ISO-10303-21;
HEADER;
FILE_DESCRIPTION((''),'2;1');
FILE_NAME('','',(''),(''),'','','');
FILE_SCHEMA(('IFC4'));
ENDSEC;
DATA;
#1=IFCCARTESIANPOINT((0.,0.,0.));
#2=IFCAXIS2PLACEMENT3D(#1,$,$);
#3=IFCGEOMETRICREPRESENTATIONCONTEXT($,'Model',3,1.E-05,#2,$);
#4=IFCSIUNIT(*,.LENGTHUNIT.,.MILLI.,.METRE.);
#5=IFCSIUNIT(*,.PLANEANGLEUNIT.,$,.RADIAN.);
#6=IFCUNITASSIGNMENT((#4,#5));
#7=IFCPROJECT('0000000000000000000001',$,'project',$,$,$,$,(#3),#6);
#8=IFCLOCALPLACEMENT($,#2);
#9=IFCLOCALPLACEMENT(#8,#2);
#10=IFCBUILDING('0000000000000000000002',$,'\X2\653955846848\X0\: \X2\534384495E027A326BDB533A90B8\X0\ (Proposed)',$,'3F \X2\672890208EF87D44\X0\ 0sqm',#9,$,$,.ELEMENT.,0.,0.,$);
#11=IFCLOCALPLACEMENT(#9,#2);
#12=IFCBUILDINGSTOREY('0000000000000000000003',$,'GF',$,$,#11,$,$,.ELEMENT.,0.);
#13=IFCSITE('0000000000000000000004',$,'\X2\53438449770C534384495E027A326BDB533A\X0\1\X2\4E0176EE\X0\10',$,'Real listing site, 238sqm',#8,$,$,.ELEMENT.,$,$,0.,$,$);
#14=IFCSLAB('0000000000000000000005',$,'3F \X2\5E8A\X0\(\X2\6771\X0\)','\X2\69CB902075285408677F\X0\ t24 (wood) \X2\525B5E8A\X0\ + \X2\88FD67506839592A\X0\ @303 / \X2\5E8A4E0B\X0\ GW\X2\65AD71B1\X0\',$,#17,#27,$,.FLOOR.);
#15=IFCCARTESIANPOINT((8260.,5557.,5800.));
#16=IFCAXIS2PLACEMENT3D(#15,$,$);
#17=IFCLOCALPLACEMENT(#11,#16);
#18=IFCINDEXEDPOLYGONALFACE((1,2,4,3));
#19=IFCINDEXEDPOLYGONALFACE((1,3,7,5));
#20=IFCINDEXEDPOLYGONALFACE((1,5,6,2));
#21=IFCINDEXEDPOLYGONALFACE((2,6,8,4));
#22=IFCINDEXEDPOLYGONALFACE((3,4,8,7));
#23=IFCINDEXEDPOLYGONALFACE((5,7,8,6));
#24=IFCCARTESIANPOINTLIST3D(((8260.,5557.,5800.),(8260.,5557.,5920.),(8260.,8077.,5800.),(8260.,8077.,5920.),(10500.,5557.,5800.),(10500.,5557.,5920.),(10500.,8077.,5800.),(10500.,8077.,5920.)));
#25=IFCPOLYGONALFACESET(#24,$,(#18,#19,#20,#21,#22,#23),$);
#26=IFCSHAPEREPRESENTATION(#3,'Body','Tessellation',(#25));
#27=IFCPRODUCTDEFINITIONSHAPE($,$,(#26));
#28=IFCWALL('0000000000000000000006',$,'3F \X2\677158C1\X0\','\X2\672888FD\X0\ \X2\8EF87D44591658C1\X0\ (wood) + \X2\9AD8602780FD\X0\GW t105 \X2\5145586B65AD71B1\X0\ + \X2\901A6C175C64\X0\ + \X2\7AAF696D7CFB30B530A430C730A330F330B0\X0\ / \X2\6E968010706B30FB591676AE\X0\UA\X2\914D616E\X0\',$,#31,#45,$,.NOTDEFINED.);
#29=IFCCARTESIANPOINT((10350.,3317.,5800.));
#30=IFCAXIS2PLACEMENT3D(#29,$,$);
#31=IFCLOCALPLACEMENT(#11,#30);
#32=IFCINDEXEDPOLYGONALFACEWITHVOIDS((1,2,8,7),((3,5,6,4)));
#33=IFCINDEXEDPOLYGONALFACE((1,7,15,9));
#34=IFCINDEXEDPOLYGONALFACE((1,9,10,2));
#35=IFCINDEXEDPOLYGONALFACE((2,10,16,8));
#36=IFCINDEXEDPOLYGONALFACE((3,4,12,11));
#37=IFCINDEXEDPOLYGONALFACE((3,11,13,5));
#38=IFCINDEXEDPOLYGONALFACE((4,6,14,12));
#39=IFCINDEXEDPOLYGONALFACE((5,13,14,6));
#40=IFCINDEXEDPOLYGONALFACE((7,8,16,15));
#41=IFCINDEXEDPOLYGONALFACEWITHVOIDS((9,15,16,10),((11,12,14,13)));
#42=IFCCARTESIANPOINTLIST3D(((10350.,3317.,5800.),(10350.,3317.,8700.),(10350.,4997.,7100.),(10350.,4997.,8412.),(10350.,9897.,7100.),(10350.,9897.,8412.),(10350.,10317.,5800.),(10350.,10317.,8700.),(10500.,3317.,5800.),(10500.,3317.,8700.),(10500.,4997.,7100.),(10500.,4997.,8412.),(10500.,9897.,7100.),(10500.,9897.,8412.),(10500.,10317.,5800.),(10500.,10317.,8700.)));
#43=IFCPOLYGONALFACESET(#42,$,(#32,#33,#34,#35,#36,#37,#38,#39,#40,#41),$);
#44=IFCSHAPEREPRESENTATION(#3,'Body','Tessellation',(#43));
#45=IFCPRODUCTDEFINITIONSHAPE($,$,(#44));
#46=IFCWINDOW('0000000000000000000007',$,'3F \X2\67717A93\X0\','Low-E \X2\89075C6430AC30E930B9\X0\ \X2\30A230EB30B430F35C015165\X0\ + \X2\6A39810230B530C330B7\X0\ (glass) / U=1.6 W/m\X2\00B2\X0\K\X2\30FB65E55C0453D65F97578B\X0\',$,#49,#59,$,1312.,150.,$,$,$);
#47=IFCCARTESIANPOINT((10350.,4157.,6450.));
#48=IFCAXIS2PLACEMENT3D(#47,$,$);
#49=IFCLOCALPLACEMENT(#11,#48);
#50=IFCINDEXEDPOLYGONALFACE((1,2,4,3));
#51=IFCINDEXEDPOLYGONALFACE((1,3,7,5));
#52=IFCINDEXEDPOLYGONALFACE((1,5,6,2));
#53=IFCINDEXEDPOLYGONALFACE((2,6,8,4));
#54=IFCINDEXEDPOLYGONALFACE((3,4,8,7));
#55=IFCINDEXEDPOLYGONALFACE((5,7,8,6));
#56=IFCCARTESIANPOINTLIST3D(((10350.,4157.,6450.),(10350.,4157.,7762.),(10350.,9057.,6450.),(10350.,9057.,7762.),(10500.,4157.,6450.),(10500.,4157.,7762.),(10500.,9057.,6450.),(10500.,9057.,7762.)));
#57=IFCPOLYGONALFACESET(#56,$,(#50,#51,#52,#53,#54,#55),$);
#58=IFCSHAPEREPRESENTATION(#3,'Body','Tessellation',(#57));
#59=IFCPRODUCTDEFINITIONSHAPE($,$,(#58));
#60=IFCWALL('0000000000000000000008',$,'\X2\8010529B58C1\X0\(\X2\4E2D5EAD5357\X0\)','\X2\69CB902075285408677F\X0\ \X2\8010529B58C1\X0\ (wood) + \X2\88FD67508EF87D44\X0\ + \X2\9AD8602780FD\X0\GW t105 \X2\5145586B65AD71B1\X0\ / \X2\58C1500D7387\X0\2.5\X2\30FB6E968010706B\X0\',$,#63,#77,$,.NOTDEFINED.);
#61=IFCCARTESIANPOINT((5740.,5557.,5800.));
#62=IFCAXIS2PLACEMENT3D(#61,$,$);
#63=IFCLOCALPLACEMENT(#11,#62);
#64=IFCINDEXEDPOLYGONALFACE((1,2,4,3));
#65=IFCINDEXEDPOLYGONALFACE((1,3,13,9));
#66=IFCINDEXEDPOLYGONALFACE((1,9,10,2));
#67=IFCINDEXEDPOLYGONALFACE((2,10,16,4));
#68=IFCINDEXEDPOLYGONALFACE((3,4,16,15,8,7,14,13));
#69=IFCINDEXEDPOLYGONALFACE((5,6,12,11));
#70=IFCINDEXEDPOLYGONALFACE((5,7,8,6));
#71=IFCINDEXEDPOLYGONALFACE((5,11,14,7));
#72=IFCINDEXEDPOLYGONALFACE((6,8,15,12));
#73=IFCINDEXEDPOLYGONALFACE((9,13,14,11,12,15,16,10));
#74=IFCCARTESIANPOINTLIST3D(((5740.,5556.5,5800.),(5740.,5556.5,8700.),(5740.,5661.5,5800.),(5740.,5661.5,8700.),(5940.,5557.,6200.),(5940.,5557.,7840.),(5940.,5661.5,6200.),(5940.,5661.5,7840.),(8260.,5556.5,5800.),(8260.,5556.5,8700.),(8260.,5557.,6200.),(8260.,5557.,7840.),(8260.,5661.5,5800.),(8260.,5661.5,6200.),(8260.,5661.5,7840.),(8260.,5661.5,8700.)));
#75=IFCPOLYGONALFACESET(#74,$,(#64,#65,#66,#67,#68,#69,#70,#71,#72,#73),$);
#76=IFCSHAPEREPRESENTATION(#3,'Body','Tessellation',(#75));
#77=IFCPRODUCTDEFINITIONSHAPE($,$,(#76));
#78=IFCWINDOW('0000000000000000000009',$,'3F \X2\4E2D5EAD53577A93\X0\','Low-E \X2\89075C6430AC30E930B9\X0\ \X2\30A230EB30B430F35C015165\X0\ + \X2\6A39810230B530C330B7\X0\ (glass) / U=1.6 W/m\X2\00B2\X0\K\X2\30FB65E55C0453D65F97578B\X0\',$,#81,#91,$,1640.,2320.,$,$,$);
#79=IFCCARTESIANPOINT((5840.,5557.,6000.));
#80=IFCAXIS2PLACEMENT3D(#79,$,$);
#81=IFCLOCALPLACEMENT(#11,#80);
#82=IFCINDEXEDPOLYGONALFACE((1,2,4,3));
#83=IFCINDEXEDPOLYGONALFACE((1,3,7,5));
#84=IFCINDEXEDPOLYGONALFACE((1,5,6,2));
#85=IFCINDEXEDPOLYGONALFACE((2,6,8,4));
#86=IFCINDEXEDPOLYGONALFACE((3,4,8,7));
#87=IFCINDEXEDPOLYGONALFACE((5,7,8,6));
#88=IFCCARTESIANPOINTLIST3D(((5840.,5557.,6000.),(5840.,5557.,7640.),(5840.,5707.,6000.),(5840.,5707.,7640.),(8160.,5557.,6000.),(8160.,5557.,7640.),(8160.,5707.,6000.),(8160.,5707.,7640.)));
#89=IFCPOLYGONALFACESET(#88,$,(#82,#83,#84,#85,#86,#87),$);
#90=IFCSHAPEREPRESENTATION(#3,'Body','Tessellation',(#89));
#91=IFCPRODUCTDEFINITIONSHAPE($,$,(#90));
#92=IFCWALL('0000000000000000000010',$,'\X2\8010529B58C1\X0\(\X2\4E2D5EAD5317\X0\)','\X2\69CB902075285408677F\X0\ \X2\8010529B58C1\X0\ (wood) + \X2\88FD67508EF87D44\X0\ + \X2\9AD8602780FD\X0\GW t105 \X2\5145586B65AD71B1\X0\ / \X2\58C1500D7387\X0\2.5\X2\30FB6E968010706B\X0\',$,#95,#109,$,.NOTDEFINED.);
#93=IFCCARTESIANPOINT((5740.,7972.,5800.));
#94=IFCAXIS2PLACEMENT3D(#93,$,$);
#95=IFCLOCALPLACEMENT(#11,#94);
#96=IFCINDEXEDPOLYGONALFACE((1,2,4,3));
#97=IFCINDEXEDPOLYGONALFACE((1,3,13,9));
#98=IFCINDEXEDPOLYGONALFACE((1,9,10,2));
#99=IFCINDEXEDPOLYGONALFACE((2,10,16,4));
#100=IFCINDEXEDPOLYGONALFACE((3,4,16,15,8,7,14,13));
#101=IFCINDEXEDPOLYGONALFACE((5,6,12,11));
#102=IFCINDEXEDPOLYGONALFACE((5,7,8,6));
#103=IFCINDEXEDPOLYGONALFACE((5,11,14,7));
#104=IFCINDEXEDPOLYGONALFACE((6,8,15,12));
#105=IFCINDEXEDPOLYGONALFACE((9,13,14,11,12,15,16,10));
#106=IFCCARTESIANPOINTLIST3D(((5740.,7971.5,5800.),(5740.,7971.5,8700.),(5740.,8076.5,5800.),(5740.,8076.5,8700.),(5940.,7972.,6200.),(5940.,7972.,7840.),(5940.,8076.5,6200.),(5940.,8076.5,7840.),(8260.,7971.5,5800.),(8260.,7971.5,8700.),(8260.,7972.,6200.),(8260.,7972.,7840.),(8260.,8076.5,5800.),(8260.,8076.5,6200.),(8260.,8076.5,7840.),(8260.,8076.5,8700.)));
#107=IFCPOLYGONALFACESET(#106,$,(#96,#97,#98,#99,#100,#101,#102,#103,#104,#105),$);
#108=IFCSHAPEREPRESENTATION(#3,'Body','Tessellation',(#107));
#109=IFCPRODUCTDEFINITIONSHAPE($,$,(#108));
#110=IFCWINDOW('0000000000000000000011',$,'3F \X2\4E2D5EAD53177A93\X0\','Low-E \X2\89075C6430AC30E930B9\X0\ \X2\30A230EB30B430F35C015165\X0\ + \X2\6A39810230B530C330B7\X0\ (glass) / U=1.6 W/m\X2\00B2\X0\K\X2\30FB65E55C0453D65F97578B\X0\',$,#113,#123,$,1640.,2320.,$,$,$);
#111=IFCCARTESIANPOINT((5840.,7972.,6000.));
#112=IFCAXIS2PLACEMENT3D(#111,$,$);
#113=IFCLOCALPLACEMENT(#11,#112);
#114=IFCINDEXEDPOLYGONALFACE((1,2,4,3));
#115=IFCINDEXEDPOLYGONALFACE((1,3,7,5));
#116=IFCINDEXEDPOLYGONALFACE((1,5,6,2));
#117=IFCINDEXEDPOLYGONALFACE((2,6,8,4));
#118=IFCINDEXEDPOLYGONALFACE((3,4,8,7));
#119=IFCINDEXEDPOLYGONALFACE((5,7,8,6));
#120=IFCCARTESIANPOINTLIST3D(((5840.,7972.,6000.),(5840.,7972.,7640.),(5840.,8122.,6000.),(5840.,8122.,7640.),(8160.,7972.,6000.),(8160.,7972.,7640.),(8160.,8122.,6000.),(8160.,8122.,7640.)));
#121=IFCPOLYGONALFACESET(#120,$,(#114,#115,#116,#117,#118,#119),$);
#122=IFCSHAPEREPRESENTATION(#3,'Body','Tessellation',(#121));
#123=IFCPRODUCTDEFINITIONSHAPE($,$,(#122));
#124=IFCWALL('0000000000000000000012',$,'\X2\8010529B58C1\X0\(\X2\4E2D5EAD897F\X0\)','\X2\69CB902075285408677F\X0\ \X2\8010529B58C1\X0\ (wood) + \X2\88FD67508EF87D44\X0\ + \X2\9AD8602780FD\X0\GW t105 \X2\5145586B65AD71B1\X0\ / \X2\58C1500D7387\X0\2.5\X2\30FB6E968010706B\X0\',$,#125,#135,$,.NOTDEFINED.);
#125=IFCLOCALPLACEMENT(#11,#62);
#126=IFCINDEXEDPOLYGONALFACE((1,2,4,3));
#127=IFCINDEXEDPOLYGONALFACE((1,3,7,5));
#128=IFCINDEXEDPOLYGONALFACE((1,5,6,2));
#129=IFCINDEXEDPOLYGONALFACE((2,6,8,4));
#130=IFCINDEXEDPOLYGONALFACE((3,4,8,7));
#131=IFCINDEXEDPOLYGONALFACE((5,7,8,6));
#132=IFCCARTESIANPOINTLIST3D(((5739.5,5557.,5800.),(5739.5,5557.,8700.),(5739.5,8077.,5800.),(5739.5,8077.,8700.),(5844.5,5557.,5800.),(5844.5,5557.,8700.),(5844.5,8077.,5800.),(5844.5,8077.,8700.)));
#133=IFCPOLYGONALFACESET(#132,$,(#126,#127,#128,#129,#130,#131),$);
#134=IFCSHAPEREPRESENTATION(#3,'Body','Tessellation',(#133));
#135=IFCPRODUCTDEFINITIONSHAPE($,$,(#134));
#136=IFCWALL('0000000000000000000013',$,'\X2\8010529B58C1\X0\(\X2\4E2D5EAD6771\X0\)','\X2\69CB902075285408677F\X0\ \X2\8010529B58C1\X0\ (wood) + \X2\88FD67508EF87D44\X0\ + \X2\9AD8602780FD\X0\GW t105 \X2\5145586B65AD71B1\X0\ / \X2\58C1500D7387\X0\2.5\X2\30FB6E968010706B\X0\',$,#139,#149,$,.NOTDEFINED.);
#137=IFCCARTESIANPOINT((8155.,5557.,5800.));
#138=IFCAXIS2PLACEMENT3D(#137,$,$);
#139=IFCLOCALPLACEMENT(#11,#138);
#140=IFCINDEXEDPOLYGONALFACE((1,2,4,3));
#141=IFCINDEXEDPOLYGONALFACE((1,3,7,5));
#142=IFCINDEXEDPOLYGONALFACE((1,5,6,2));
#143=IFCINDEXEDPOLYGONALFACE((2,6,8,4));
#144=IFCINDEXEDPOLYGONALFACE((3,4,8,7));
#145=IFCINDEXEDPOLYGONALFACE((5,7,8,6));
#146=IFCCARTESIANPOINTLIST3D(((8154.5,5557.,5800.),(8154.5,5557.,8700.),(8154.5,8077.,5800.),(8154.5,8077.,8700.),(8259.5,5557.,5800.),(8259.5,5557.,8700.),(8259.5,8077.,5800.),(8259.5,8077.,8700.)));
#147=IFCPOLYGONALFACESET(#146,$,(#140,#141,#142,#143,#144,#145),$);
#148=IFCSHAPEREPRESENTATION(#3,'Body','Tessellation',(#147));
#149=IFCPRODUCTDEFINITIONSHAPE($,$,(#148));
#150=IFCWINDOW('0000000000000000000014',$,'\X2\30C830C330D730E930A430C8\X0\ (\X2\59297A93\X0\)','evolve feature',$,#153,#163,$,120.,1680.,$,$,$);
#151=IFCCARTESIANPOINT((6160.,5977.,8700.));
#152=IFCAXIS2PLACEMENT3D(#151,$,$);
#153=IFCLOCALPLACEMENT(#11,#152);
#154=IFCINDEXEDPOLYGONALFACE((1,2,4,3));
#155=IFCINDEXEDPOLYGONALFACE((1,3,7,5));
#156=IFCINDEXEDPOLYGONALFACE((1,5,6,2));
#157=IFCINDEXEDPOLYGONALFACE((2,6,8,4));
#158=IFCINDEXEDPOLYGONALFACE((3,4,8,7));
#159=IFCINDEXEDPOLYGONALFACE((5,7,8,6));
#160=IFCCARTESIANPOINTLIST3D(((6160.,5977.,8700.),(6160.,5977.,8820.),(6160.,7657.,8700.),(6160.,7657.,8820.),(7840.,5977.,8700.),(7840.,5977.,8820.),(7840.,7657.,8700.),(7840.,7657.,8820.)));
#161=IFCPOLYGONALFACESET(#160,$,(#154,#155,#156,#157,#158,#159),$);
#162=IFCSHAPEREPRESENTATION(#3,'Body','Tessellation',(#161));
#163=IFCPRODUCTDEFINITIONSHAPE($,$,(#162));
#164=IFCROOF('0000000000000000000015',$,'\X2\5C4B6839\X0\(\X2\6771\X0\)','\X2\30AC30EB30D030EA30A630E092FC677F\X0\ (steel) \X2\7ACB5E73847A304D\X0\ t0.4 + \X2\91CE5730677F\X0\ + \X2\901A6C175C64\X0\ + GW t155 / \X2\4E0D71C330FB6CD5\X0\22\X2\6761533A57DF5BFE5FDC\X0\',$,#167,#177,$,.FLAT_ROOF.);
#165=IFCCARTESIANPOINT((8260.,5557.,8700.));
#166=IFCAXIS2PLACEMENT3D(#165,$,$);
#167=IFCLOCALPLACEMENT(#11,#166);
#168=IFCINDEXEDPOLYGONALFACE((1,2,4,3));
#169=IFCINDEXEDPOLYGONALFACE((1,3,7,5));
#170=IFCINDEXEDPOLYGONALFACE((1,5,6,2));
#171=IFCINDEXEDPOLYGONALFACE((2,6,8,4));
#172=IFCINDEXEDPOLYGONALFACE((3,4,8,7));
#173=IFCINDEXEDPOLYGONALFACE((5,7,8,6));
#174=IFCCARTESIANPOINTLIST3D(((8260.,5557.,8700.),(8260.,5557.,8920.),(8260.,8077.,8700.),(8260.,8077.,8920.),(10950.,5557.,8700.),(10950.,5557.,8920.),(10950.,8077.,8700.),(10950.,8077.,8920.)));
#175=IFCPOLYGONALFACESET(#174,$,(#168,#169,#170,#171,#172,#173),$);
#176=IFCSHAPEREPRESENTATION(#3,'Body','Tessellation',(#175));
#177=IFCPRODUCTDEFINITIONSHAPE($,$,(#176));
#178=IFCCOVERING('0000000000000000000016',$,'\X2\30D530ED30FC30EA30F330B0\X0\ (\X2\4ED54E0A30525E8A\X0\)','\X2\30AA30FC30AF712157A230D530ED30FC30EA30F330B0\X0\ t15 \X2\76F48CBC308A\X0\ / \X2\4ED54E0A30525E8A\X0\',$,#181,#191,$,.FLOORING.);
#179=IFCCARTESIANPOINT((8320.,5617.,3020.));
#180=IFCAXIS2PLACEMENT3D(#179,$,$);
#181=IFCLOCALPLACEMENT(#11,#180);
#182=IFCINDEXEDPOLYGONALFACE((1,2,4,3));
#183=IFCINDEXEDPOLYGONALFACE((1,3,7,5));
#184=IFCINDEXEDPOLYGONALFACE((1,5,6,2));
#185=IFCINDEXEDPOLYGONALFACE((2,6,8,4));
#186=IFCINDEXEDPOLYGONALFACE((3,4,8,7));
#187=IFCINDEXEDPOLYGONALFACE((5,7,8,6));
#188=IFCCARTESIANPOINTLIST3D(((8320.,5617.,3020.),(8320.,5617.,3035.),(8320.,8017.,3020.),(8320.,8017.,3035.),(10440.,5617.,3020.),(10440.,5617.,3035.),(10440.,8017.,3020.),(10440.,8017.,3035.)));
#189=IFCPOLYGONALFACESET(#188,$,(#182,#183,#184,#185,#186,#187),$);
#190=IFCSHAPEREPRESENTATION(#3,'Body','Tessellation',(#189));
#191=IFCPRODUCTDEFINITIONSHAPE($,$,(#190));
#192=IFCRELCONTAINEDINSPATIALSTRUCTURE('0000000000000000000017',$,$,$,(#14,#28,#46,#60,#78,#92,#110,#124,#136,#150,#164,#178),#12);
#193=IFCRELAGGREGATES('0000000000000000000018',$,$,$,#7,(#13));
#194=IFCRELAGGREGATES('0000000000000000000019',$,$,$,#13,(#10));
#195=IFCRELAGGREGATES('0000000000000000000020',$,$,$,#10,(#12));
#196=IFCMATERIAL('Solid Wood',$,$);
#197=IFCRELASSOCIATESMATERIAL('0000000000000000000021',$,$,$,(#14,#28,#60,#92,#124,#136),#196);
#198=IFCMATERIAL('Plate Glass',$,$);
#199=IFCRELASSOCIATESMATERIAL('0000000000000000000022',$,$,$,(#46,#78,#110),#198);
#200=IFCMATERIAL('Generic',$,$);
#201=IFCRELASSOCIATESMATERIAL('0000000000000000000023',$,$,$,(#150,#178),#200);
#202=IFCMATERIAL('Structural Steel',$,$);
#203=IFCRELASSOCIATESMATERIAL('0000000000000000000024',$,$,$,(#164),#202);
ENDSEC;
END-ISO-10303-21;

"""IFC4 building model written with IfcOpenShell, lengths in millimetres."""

from ifc_helpers import new_model, si_unit, frame, frame_2d, origin, place, context, project, spatial, rectangle, extrude, material, element, fill, save


model = new_model("IFC4")

# Units and contexts
model_context = context("Model", 3, precision=1e-05, world=origin())
ifc_project = project(units=[si_unit("LENGTHUNIT", "METRE", prefix="MILLI"), si_unit("PLANEANGLEUNIT", "RADIAN")], contexts=[model_context])

# Site, building, storey
site_placement = place(None, origin())
site = spatial("IfcSite", under=ifc_project, at=site_placement, Name="千葉県千葉市稲毛区1丁目10", ObjectType="Real listing site, 238sqm", CompositionType="ELEMENT", RefElevation=0.0)
building_placement = place(site_placement, origin())
building = spatial("IfcBuilding", under=site, at=building_placement, Name="改善案: 千葉市稲毛区邸 (Proposed)", ObjectType="3F 木造軸組 0sqm", CompositionType="ELEMENT", ElevationOfRefHeight=0.0, ElevationOfTerrain=0.0)
storey_placement = place(building_placement, origin())
storey = spatial("IfcBuildingStorey", under=building, at=storey_placement, Name="GF", CompositionType="ELEMENT", Elevation=0.0)

# Slab
ifc_material_1 = material(Name="Solid Wood")
slab_placement = place(storey_placement, frame((8260.0, 5557.0, 5800.0)))
element("IfcSlab", 1, at=slab_placement, inside=storey, material=ifc_material_1, Name="3F 床(東)", Description="構造用合板 t24 (wood) 剛床 + 製材根太 @303 / 床下 GW断熱", PredefinedType="FLOOR", context=model_context, shape_type="SweptSolid", body=[
    extrude(rectangle(XDim=2240.0, YDim=2520.0, at=frame_2d((1120.0, 1260.0))), frame((8260.0, 5557.0, 5800.0)), (0.0, 0.0, 1.0), 120.0),
])

# Walls, openings, windows
wall_1_placement = place(storey_placement, frame((10350.0, 3317.0, 5800.0)))
wall_1 = element("IfcWall", 2, at=wall_1_placement, inside=storey, material=ifc_material_1, Name="3F 東壁", Description="木製 軸組外壁 (wood) + 高性能GW t105 充填断熱 + 通気層 + 窯業系サイディング / 準耐火・外皮UA配慮", PredefinedType="NOTDEFINED", context=model_context, shape_type="SweptSolid", body=[
    extrude(rectangle(XDim=150.0, YDim=7000.0, at=frame_2d((75.0, 3500.0))), frame((10350.0, 3317.0, 5800.0)), (0.0, 0.0, 1.0), 2900.0),
])
opening_1_placement = place(storey_placement, frame((10350.0, 4157.0, 6450.0)))
opening_1 = element("IfcOpeningElement", 3, at=opening_1_placement, cuts=wall_1, PredefinedType="NOTDEFINED", context=model_context, shape_type="SweptSolid", body=[
    extrude(rectangle(XDim=150.0, YDim=4900.0, at=frame_2d((75.0, 2450.0))), frame((10350.0, 4157.0, 6450.0)), (0.0, 0.0, 1.0), 1312.0),
])
ifc_material_2 = material(Name="Plate Glass")
window_1_placement = place(storey_placement, frame((10350.0, 4157.0, 6450.0)))
window_1 = element("IfcWindow", 4, at=window_1_placement, inside=storey, material=ifc_material_2, Name="3F 東窓", Description="Low-E 複層ガラス アルゴン封入 + 樹脂サッシ (glass) / U=1.6 W/m²K・日射取得型", OverallHeight=1312.0, OverallWidth=150.0, context=model_context, shape_type="SweptSolid", body=[
    extrude(rectangle(XDim=150.0, YDim=4900.0, at=frame_2d((75.0, 2450.0))), frame((10350.0, 4157.0, 6450.0)), (0.0, 0.0, 1.0), 1312.0),
])
fill(opening_1, window_1)
wall_2_placement = place(storey_placement, frame((5740.0, 5557.0, 5800.0)))
wall_2 = element("IfcWall", 5, at=wall_2_placement, inside=storey, material=ifc_material_1, Name="耐力壁(中庭南)", Description="構造用合板 耐力壁 (wood) + 製材軸組 + 高性能GW t105 充填断熱 / 壁倍率2.5・準耐火", PredefinedType="NOTDEFINED", context=model_context, shape_type="SweptSolid", body=[
    extrude(rectangle(XDim=2520.0, YDim=105.0, at=frame_2d((1260.0, 52.0))), frame((5740.0, 5557.0, 5800.0)), (0.0, 0.0, 1.0), 2900.0),
])
opening_2_placement = place(storey_placement, frame((5840.0, 5557.0, 6000.0)))
opening_2 = element("IfcOpeningElement", 6, at=opening_2_placement, cuts=wall_2, PredefinedType="NOTDEFINED", context=model_context, shape_type="SweptSolid", body=[
    extrude(rectangle(XDim=2320.0, YDim=150.0, at=frame_2d((1160.0, 75.0))), frame((5840.0, 5557.0, 6000.0)), (0.0, 0.0, 1.0), 1640.0),
])
window_2_placement = place(storey_placement, frame((5840.0, 5557.0, 6000.0)))
window_2 = element("IfcWindow", 7, at=window_2_placement, inside=storey, material=ifc_material_2, Name="3F 中庭南窓", Description="Low-E 複層ガラス アルゴン封入 + 樹脂サッシ (glass) / U=1.6 W/m²K・日射取得型", OverallHeight=1640.0, OverallWidth=2320.0, context=model_context, shape_type="SweptSolid", body=[
    extrude(rectangle(XDim=2320.0, YDim=150.0, at=frame_2d((1160.0, 75.0))), frame((5840.0, 5557.0, 6000.0)), (0.0, 0.0, 1.0), 1640.0),
])
fill(opening_2, window_2)
wall_3_placement = place(storey_placement, frame((5740.0, 7972.0, 5800.0)))
wall_3 = element("IfcWall", 8, at=wall_3_placement, inside=storey, material=ifc_material_1, Name="耐力壁(中庭北)", Description="構造用合板 耐力壁 (wood) + 製材軸組 + 高性能GW t105 充填断熱 / 壁倍率2.5・準耐火", PredefinedType="NOTDEFINED", context=model_context, shape_type="SweptSolid", body=[
    extrude(rectangle(XDim=2520.0, YDim=105.0, at=frame_2d((1260.0, 52.0))), frame((5740.0, 7972.0, 5800.0)), (0.0, 0.0, 1.0), 2900.0),
])
opening_3_placement = place(storey_placement, frame((5840.0, 7972.0, 6000.0)))
opening_3 = element("IfcOpeningElement", 9, at=opening_3_placement, cuts=wall_3, PredefinedType="NOTDEFINED", context=model_context, shape_type="SweptSolid", body=[
    extrude(rectangle(XDim=2320.0, YDim=150.0, at=frame_2d((1160.0, 75.0))), frame((5840.0, 7972.0, 6000.0)), (0.0, 0.0, 1.0), 1640.0),
])
window_3_placement = place(storey_placement, frame((5840.0, 7972.0, 6000.0)))
window_3 = element("IfcWindow", 10, at=window_3_placement, inside=storey, material=ifc_material_2, Name="3F 中庭北窓", Description="Low-E 複層ガラス アルゴン封入 + 樹脂サッシ (glass) / U=1.6 W/m²K・日射取得型", OverallHeight=1640.0, OverallWidth=2320.0, context=model_context, shape_type="SweptSolid", body=[
    extrude(rectangle(XDim=2320.0, YDim=150.0, at=frame_2d((1160.0, 75.0))), frame((5840.0, 7972.0, 6000.0)), (0.0, 0.0, 1.0), 1640.0),
])
fill(opening_3, window_3)

# Walls
wall_4_placement = place(storey_placement, frame((5740.0, 5557.0, 5800.0)))
element("IfcWall", 11, at=wall_4_placement, inside=storey, material=ifc_material_1, Name="耐力壁(中庭西)", Description="構造用合板 耐力壁 (wood) + 製材軸組 + 高性能GW t105 充填断熱 / 壁倍率2.5・準耐火", PredefinedType="NOTDEFINED", context=model_context, shape_type="SweptSolid", body=[
    extrude(rectangle(XDim=105.0, YDim=2520.0, at=frame_2d((52.0, 1260.0))), frame((5740.0, 5557.0, 5800.0)), (0.0, 0.0, 1.0), 2900.0),
])
wall_5_placement = place(storey_placement, frame((8155.0, 5557.0, 5800.0)))
element("IfcWall", 12, at=wall_5_placement, inside=storey, material=ifc_material_1, Name="耐力壁(中庭東)", Description="構造用合板 耐力壁 (wood) + 製材軸組 + 高性能GW t105 充填断熱 / 壁倍率2.5・準耐火", PredefinedType="NOTDEFINED", context=model_context, shape_type="SweptSolid", body=[
    extrude(rectangle(XDim=105.0, YDim=2520.0, at=frame_2d((52.0, 1260.0))), frame((8155.0, 5557.0, 5800.0)), (0.0, 0.0, 1.0), 2900.0),
])

# Window
ifc_material_3 = material(Name="Generic")
window_4_placement = place(storey_placement, frame((6160.0, 5977.0, 8700.0)))
element("IfcWindow", 13, at=window_4_placement, inside=storey, material=ifc_material_3, Name="トップライト (天窓)", Description="evolve feature", OverallHeight=120.0, OverallWidth=1680.0, context=model_context, shape_type="SweptSolid", body=[
    extrude(rectangle(XDim=1680.0, YDim=1680.0, at=frame_2d((840.0, 840.0))), frame((6160.0, 5977.0, 8700.0)), (0.0, 0.0, 1.0), 120.0),
])

# Roof
ifc_material_4 = material(Name="Structural Steel")
for number, where, name in (
    (14, (8260.0, 5557.0, 8700.0), "屋根(東)"),
):
    element("IfcRoof", number, at=place(storey_placement, frame(where)), inside=storey, material=ifc_material_4, Name=name, Description="ガルバリウム鋼板 (steel) 立平葺き t0.4 + 野地板 + 通気層 + GW t155 / 不燃・法22条区域対応", PredefinedType="FLAT_ROOF", context=model_context, shape_type="SweptSolid", body=[
        extrude(rectangle(XDim=2690.0, YDim=2520.0, at=frame_2d((1345.0, 1260.0))), frame((8260.0, 5557.0, 8700.0)), (0.0, 0.0, 1.0), 220.0),
    ])

# Covering
covering_1_placement = place(storey_placement, frame((8320.0, 5617.0, 3020.0)))
element("IfcCovering", 15, at=covering_1_placement, inside=storey, material=ifc_material_3, Name="フローリング (仕上げ床)", Description="オーク無垢フローリング t15 直貼り / 仕上げ床", PredefinedType="FLOORING", context=model_context, shape_type="SweptSolid", body=[
    extrude(rectangle(XDim=2120.0, YDim=2400.0, at=frame_2d((1060.0, 1200.0))), frame((8320.0, 5617.0, 3020.0)), (0.0, 0.0, 1.0), 15.0),
])

save(model, "model.ifc")
